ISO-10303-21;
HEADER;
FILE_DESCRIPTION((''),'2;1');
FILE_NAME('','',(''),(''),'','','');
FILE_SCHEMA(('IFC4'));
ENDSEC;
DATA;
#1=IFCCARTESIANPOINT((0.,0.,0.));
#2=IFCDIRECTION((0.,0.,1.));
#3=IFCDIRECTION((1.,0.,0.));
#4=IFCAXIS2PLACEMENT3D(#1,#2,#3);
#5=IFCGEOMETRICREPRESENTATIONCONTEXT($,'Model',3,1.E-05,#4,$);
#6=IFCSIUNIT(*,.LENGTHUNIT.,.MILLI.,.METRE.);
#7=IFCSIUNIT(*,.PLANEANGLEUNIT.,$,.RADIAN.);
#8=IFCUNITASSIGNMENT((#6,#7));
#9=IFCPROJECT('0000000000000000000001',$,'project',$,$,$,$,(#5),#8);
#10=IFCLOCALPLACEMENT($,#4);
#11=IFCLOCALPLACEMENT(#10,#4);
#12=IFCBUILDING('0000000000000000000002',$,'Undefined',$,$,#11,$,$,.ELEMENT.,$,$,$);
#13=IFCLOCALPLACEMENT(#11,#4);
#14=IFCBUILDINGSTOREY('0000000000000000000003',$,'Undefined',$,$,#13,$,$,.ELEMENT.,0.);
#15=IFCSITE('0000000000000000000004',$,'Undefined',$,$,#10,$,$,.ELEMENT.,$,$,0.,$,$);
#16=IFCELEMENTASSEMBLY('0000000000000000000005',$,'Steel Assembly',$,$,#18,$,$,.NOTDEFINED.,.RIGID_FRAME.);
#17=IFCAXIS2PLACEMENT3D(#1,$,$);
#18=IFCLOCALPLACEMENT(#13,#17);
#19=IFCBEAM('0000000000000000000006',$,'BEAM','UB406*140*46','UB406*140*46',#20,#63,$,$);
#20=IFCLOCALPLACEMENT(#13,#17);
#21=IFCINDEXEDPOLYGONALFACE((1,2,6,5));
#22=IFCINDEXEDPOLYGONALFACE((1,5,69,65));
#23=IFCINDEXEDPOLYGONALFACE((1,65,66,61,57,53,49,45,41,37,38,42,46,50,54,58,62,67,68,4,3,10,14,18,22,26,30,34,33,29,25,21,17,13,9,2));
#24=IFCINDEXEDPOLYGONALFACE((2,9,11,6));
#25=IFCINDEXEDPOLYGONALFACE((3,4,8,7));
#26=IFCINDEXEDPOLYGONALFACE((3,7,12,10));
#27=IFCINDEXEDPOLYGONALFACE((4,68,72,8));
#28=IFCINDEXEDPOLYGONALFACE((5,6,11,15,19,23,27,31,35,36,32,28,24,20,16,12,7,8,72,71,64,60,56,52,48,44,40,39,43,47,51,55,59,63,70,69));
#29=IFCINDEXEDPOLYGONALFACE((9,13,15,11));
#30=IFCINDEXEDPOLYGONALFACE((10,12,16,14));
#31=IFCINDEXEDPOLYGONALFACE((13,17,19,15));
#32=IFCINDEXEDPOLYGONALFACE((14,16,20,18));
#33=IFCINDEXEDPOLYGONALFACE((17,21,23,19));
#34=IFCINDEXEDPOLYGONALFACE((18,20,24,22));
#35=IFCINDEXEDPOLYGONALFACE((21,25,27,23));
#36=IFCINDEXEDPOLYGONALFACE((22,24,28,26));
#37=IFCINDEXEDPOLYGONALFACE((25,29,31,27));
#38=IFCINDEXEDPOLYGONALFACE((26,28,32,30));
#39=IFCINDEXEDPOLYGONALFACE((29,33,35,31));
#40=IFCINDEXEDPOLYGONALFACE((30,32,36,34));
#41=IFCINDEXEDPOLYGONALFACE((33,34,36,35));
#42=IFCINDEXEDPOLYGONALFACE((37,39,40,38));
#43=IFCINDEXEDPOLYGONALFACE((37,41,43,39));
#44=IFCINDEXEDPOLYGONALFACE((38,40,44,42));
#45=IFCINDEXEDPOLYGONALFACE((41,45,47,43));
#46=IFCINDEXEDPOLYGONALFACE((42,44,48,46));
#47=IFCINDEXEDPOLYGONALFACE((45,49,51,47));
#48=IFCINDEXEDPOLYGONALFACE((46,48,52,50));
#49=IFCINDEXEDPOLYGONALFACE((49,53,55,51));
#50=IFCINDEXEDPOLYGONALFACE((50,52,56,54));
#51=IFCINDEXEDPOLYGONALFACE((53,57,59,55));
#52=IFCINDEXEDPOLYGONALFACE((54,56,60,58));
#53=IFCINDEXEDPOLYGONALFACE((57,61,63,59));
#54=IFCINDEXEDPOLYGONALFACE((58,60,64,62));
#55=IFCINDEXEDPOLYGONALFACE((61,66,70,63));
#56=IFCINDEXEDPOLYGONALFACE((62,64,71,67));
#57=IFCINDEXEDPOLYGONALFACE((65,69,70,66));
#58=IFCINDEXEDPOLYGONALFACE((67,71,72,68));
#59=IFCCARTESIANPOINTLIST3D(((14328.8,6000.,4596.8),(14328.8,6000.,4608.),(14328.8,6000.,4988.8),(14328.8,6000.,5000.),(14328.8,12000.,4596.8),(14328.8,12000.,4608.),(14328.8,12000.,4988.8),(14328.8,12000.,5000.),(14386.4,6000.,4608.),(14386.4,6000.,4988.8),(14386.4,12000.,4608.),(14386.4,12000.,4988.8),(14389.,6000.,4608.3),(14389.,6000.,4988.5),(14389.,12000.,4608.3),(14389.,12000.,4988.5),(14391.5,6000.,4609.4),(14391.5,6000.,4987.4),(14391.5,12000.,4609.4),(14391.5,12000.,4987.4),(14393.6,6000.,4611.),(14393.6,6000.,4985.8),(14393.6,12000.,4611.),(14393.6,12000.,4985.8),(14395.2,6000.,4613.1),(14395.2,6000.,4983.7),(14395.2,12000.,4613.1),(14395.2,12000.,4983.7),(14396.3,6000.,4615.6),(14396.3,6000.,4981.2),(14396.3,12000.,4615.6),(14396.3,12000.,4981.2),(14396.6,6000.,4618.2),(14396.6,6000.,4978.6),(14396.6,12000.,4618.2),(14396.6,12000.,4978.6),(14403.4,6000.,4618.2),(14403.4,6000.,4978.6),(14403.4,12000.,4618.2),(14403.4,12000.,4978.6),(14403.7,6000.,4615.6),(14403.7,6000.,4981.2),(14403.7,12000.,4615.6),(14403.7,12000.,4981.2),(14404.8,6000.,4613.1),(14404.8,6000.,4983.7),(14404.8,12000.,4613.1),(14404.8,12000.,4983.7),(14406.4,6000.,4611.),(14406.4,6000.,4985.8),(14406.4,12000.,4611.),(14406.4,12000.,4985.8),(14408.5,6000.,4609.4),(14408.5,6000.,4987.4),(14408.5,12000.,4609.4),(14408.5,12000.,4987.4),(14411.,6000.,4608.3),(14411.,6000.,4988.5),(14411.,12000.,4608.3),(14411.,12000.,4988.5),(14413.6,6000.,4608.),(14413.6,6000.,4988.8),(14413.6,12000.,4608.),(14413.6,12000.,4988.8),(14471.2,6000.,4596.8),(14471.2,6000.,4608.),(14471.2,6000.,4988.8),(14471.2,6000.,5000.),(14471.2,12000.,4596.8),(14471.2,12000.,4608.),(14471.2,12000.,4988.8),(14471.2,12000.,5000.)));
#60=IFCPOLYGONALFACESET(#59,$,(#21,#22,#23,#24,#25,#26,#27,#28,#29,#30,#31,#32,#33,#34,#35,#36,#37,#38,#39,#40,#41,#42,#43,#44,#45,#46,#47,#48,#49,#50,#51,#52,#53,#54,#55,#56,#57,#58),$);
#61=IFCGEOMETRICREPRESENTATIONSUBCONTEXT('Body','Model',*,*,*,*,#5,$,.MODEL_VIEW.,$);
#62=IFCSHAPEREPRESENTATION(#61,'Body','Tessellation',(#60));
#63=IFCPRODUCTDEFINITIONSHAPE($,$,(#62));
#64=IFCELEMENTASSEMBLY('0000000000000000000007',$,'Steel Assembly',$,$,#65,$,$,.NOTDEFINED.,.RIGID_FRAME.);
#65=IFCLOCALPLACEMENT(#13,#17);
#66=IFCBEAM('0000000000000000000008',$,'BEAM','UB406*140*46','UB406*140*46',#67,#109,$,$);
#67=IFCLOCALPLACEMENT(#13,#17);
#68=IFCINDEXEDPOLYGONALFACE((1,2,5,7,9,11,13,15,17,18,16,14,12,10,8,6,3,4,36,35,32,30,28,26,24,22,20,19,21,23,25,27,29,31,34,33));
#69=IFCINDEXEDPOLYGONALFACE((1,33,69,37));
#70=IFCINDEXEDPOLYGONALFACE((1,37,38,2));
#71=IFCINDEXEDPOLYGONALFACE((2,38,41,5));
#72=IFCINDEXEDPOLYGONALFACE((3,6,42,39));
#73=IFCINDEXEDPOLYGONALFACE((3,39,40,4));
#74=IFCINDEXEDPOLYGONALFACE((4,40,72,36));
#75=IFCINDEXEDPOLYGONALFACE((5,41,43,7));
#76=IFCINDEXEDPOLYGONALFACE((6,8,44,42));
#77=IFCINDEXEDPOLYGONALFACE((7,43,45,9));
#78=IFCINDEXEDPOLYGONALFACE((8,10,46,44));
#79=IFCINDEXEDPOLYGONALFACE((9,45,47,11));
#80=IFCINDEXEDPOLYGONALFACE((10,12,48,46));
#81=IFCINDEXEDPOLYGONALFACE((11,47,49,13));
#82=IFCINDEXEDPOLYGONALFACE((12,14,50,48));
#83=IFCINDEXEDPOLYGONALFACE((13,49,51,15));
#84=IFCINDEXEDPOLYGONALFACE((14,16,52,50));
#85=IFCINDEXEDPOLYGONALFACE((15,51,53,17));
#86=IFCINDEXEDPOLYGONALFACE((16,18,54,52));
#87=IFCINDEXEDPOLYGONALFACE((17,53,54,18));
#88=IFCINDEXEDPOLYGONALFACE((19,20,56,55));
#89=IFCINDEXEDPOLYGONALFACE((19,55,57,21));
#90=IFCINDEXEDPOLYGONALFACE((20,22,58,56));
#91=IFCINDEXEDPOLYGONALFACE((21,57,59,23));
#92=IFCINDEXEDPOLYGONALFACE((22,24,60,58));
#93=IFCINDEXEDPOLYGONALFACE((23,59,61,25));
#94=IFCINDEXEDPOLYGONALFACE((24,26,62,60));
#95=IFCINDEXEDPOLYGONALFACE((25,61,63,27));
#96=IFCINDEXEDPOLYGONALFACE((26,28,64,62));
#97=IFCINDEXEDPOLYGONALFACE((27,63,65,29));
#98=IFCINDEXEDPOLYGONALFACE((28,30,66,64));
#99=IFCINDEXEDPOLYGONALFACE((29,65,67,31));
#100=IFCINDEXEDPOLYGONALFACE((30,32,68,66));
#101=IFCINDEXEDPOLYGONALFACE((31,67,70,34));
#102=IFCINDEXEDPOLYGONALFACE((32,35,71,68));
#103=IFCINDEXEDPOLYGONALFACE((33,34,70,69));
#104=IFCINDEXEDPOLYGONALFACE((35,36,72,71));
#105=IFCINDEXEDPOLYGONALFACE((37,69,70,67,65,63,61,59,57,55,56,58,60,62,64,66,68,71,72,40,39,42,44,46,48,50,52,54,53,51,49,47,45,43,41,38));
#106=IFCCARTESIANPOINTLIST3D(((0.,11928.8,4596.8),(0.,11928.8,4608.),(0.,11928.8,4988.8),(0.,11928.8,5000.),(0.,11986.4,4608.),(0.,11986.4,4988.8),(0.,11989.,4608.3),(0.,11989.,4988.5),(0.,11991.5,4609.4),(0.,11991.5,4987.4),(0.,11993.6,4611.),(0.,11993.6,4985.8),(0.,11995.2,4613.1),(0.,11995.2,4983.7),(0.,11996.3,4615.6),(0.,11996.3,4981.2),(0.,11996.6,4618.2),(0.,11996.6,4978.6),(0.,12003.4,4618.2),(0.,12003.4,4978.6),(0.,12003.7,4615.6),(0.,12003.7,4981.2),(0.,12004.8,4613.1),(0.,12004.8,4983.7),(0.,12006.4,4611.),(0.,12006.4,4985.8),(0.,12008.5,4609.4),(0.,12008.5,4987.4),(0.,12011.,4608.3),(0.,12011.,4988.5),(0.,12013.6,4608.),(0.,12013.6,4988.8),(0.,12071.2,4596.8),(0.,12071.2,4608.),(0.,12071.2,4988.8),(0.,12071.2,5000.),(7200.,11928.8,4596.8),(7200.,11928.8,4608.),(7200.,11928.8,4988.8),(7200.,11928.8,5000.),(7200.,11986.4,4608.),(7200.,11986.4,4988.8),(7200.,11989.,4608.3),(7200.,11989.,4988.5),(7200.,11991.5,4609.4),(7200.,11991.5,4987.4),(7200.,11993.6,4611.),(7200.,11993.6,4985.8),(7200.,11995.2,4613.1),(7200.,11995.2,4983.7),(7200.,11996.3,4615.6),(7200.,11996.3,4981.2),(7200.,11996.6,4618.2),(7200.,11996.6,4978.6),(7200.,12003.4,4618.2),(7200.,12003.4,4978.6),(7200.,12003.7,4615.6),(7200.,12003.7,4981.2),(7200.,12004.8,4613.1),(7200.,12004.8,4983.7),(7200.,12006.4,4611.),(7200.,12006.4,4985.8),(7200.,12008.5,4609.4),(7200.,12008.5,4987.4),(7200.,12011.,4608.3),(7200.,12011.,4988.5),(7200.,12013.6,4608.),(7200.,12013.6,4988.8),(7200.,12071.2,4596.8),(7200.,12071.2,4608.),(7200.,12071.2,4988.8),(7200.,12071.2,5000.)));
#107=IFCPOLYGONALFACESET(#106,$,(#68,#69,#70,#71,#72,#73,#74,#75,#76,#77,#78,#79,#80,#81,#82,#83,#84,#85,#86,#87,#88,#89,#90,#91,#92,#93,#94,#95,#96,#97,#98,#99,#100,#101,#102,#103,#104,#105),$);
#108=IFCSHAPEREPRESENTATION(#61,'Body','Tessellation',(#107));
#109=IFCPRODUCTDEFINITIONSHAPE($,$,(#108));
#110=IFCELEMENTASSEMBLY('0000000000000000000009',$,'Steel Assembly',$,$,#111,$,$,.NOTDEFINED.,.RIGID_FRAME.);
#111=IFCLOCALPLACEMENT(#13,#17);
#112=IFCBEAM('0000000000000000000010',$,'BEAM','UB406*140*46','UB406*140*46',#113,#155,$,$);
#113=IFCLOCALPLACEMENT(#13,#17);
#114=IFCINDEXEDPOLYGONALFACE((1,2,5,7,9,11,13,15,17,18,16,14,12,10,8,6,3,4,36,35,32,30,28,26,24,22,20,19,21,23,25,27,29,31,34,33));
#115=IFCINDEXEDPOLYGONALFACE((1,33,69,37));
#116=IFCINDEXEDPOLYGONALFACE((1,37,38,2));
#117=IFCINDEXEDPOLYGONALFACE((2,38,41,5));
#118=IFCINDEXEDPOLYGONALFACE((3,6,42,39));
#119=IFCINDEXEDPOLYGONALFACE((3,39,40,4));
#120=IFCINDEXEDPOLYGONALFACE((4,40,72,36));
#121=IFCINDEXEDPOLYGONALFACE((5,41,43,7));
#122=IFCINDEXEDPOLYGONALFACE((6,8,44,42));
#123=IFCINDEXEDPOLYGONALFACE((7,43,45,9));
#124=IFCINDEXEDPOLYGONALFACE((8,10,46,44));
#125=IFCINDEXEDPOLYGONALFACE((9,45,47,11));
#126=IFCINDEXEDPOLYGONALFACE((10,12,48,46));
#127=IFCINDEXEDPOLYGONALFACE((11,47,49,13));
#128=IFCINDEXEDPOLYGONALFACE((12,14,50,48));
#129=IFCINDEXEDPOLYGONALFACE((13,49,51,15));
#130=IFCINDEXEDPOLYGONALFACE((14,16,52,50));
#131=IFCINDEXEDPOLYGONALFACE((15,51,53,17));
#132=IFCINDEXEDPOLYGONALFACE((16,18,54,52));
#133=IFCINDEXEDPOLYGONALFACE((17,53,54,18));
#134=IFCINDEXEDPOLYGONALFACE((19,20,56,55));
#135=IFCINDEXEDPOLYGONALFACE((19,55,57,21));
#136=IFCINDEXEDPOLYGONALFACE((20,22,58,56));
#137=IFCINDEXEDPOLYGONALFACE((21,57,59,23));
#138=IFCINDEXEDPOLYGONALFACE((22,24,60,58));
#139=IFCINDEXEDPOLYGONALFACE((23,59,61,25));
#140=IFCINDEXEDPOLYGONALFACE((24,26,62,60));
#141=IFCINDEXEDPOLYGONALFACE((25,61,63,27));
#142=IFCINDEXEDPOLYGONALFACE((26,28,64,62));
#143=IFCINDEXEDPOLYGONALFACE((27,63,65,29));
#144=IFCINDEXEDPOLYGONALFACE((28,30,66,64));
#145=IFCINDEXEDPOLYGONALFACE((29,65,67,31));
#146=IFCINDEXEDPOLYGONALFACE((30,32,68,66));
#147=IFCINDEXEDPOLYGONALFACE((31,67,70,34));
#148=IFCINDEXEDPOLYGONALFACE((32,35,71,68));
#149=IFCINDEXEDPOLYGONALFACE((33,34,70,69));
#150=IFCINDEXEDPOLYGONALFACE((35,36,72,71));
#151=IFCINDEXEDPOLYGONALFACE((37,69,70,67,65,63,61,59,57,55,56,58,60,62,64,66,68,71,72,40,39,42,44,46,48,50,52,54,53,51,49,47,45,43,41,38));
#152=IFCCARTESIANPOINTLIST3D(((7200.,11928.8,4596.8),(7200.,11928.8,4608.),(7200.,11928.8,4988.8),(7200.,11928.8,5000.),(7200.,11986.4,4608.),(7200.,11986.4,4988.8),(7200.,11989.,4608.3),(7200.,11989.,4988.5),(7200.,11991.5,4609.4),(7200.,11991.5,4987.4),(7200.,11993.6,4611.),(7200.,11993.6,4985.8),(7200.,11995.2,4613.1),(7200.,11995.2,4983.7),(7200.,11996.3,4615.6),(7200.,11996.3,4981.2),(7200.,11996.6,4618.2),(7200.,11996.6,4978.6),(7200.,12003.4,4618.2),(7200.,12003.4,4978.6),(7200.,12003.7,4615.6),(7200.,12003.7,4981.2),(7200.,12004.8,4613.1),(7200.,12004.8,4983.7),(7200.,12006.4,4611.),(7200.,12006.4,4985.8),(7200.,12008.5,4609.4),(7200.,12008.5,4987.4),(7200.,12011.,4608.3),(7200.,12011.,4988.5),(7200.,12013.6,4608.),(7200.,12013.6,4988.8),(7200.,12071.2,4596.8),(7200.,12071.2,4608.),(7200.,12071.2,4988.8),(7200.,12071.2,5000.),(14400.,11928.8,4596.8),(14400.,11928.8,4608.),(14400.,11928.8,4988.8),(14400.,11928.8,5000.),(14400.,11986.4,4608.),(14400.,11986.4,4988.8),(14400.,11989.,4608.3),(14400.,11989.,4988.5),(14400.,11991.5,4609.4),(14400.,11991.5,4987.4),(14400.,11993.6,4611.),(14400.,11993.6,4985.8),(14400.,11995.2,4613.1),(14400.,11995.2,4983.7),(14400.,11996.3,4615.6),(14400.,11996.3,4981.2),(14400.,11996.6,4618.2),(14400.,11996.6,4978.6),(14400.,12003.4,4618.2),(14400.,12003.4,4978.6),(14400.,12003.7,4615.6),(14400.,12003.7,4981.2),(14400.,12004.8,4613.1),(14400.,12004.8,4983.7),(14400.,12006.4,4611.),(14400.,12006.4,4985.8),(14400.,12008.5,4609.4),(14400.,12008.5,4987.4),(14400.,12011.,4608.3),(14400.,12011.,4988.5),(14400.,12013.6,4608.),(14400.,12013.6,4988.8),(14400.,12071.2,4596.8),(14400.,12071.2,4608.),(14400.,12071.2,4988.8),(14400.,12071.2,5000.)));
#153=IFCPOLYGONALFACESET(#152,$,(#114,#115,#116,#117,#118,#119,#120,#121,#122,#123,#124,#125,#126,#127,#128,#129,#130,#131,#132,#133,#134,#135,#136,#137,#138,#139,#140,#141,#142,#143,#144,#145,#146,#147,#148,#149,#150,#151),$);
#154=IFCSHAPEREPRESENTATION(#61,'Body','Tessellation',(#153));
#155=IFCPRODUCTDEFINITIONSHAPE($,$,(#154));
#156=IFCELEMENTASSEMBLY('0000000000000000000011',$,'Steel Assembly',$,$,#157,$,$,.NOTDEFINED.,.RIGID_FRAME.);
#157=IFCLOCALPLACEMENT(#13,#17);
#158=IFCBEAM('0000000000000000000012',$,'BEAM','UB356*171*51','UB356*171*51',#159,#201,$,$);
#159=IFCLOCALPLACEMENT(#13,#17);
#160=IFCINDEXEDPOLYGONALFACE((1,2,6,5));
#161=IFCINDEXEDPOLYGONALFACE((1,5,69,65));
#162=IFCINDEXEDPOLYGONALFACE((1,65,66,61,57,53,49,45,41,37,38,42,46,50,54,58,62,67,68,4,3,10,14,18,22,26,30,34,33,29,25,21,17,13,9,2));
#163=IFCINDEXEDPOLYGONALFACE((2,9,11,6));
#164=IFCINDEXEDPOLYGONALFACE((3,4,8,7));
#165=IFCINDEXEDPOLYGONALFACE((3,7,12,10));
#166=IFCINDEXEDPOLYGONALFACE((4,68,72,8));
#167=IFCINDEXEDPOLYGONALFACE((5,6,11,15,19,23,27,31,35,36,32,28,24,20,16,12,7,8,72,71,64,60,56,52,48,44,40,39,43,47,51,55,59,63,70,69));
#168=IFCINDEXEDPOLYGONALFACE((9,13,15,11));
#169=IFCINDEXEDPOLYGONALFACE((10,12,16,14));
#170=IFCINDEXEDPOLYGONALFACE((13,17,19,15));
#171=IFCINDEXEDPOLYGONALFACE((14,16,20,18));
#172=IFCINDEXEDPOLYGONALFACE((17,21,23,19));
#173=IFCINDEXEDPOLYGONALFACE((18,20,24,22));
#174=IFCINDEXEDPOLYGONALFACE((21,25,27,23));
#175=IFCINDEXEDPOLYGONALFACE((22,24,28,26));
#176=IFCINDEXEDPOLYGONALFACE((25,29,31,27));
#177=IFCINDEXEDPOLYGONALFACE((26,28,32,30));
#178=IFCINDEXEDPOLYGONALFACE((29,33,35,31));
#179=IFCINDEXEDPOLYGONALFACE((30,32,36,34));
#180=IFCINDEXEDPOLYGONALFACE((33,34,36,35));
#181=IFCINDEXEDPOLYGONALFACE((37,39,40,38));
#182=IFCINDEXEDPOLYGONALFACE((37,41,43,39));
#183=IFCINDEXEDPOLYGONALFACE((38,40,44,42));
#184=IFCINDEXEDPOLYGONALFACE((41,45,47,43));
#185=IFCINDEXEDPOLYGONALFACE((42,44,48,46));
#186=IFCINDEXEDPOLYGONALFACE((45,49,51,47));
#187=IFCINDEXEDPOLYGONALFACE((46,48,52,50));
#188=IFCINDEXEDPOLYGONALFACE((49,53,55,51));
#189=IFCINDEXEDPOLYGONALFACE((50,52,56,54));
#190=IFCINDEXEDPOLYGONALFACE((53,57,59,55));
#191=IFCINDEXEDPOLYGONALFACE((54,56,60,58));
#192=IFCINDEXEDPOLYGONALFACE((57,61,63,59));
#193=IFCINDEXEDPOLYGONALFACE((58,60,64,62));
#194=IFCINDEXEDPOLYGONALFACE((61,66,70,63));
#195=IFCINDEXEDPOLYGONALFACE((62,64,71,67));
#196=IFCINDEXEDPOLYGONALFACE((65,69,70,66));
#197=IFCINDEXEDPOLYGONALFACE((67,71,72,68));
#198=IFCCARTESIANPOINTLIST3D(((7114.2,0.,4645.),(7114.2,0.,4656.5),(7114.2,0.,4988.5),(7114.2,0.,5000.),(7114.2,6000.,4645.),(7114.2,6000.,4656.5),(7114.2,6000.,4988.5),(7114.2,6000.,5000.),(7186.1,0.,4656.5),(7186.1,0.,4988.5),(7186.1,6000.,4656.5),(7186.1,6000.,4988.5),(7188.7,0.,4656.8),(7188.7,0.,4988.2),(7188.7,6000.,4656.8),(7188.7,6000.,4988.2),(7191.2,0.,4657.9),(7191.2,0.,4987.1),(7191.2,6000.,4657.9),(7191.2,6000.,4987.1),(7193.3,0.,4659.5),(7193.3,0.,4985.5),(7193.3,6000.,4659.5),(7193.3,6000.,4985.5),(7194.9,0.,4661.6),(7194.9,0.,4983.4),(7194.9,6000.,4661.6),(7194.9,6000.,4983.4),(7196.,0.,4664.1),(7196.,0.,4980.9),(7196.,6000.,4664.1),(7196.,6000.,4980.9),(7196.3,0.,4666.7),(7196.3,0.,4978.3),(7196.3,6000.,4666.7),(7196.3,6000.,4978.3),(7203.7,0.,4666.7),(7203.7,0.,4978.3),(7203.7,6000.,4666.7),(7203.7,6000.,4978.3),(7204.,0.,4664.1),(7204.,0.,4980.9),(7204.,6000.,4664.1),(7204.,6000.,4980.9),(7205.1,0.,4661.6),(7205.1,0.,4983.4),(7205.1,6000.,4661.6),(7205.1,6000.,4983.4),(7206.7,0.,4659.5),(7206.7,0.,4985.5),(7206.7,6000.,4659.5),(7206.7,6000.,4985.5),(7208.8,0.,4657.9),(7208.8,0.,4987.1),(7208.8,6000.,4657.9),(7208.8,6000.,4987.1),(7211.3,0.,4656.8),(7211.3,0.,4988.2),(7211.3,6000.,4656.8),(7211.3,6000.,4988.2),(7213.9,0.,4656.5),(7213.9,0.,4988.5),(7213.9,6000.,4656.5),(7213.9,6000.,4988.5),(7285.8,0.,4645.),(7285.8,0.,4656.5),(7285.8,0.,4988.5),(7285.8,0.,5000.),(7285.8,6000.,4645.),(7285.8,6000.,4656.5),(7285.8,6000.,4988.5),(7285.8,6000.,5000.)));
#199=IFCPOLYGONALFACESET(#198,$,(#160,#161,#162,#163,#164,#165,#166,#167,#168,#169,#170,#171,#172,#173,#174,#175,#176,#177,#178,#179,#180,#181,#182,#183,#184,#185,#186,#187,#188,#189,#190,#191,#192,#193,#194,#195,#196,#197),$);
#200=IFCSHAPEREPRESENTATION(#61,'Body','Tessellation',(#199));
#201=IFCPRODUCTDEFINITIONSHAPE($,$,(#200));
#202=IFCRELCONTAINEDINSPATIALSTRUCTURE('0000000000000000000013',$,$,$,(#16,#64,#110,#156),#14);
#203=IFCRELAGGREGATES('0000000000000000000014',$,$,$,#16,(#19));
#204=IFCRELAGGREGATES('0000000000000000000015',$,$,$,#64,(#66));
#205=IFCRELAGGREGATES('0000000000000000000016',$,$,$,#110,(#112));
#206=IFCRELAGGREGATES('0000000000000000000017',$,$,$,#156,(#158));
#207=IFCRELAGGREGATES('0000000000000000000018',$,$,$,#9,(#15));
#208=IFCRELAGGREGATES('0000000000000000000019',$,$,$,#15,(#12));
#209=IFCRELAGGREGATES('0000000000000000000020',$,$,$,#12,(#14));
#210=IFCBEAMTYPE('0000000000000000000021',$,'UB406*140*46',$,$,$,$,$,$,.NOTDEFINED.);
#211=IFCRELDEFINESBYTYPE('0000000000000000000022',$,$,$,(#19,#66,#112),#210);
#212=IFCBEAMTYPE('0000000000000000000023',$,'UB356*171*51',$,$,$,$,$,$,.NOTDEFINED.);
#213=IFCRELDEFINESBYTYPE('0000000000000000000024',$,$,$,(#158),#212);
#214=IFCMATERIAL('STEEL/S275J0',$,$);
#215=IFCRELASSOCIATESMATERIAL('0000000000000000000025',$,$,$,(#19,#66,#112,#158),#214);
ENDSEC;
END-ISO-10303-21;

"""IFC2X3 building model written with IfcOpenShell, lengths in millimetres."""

from ifc_helpers import new_model, si_unit, frame, origin_with_axes, origin_2d_with_axis, place, context, subcontext, project, spatial, i_section, extrude, material, type_object, element, aggregate, save


model = new_model("IFC2X3")

# Units and contexts
model_context = context("Model", 3, precision=1e-05, world=origin_with_axes())
body_context = subcontext(model_context, "Body", "Model", "MODEL_VIEW")
ifc_project = project(units=[si_unit("LENGTHUNIT", "METRE", prefix="MILLI"), si_unit("PLANEANGLEUNIT", "RADIAN")], contexts=[model_context])

# Site, building, storey
site_placement = place(None, origin_with_axes())
site = spatial("IfcSite", under=ifc_project, at=site_placement, Name="Undefined", CompositionType="ELEMENT", RefElevation=0.0)
building_placement = place(site_placement, origin_with_axes())
building = spatial("IfcBuilding", under=site, at=building_placement, Name="Undefined", CompositionType="ELEMENT")
storey_placement = place(building_placement, origin_with_axes())
storey = spatial("IfcBuildingStorey", under=building, at=storey_placement, Name="Undefined", CompositionType="ELEMENT", Elevation=0.0)

# Shared definitions
ifc_material = material(Name="STEEL/S275J0")

# Element assemblies, beams
beam_type_1 = type_object("IfcBeamType", Name="UB406*140*46", PredefinedType="NOTDEFINED")
assembly_1_placement = place(storey_placement, origin_with_axes())
assembly_1 = element("IfcElementAssembly", 1, at=assembly_1_placement, inside=storey, Name="Steel Assembly", AssemblyPlace="NOTDEFINED", PredefinedType="RIGID_FRAME")
beam_1_placement = place(assembly_1_placement, frame((14400.0, 6000.0, 4798.4), z_axis=(0.0, 0.0, 1.0), x_axis=(0.0, 1.0, 0.0)))
beam_1 = element("IfcBeam", 2, at=beam_1_placement, type_object=beam_type_1, material=ifc_material, Name="BEAM", Description="UB406*140*46", ObjectType="UB406*140*46", context=body_context, shape_type="SweptSolid", body=[
    extrude(i_section(OverallWidth=142.4, OverallDepth=403.2, WebThickness=6.8, FlangeThickness=11.2, FilletRadius=10.2, at=origin_2d_with_axis()), frame((6000.0, 0.0, 0.0), z_axis=(-1.0, 0.0, 0.0), x_axis=(0.0, -1.0, 0.0)), (0.0, 0.0, 1.0), 6000.0),
])
aggregate(assembly_1, [beam_1])
assembly_2_placement = place(storey_placement, origin_with_axes())
assembly_2 = element("IfcElementAssembly", 3, at=assembly_2_placement, inside=storey, Name="Steel Assembly", AssemblyPlace="NOTDEFINED", PredefinedType="RIGID_FRAME")
beam_2_placement = place(assembly_2_placement, frame((0.0, 12000.0, 4798.4), z_axis=(0.0, 0.0, 1.0), x_axis=(1.0, 0.0, 0.0)))
beam_2 = element("IfcBeam", 4, at=beam_2_placement, type_object=beam_type_1, material=ifc_material, Name="BEAM", Description="UB406*140*46", ObjectType="UB406*140*46", context=body_context, shape_type="SweptSolid", body=[
    extrude(i_section(OverallWidth=142.4, OverallDepth=403.2, WebThickness=6.8, FlangeThickness=11.2, FilletRadius=10.2, at=origin_2d_with_axis()), frame((7200.0, 0.0, 0.0), z_axis=(-1.0, 0.0, 0.0), x_axis=(0.0, -1.0, 0.0)), (0.0, 0.0, 1.0), 7200.0),
])
aggregate(assembly_2, [beam_2])
assembly_3_placement = place(storey_placement, origin_with_axes())
assembly_3 = element("IfcElementAssembly", 5, at=assembly_3_placement, inside=storey, Name="Steel Assembly", AssemblyPlace="NOTDEFINED", PredefinedType="RIGID_FRAME")
beam_3_placement = place(assembly_3_placement, frame((7200.0, 12000.0, 4798.4), z_axis=(0.0, 0.0, 1.0), x_axis=(1.0, 0.0, 0.0)))
beam_3 = element("IfcBeam", 6, at=beam_3_placement, type_object=beam_type_1, material=ifc_material, Name="BEAM", Description="UB406*140*46", ObjectType="UB406*140*46", context=body_context, shape_type="SweptSolid", body=[
    extrude(i_section(OverallWidth=142.4, OverallDepth=403.2, WebThickness=6.8, FlangeThickness=11.2, FilletRadius=10.2, at=origin_2d_with_axis()), frame((7200.0, 0.0, 0.0), z_axis=(-1.0, 0.0, 0.0), x_axis=(0.0, -1.0, 0.0)), (0.0, 0.0, 1.0), 7200.0),
])
aggregate(assembly_3, [beam_3])
assembly_4_placement = place(storey_placement, origin_with_axes())
assembly_4 = element("IfcElementAssembly", 7, at=assembly_4_placement, inside=storey, Name="Steel Assembly", AssemblyPlace="NOTDEFINED", PredefinedType="RIGID_FRAME")
beam_type_2 = type_object("IfcBeamType", Name="UB356*171*51", PredefinedType="NOTDEFINED")
beam_4_placement = place(assembly_4_placement, frame((7200.0, 0.0, 4822.5), z_axis=(0.0, 0.0, 1.0), x_axis=(0.0, 1.0, 0.0)))
beam_4 = element("IfcBeam", 8, at=beam_4_placement, type_object=beam_type_2, material=ifc_material, Name="BEAM", Description="UB356*171*51", ObjectType="UB356*171*51", context=body_context, shape_type="SweptSolid", body=[
    extrude(i_section(OverallWidth=171.5, OverallDepth=355.0, WebThickness=7.4, FlangeThickness=11.5, FilletRadius=10.2, at=origin_2d_with_axis()), frame((6000.0, 0.0, 0.0), z_axis=(-1.0, 0.0, 0.0), x_axis=(0.0, -1.0, 0.0)), (0.0, 0.0, 1.0), 6000.0),
])
aggregate(assembly_4, [beam_4])

save(model, "model.ifc")
